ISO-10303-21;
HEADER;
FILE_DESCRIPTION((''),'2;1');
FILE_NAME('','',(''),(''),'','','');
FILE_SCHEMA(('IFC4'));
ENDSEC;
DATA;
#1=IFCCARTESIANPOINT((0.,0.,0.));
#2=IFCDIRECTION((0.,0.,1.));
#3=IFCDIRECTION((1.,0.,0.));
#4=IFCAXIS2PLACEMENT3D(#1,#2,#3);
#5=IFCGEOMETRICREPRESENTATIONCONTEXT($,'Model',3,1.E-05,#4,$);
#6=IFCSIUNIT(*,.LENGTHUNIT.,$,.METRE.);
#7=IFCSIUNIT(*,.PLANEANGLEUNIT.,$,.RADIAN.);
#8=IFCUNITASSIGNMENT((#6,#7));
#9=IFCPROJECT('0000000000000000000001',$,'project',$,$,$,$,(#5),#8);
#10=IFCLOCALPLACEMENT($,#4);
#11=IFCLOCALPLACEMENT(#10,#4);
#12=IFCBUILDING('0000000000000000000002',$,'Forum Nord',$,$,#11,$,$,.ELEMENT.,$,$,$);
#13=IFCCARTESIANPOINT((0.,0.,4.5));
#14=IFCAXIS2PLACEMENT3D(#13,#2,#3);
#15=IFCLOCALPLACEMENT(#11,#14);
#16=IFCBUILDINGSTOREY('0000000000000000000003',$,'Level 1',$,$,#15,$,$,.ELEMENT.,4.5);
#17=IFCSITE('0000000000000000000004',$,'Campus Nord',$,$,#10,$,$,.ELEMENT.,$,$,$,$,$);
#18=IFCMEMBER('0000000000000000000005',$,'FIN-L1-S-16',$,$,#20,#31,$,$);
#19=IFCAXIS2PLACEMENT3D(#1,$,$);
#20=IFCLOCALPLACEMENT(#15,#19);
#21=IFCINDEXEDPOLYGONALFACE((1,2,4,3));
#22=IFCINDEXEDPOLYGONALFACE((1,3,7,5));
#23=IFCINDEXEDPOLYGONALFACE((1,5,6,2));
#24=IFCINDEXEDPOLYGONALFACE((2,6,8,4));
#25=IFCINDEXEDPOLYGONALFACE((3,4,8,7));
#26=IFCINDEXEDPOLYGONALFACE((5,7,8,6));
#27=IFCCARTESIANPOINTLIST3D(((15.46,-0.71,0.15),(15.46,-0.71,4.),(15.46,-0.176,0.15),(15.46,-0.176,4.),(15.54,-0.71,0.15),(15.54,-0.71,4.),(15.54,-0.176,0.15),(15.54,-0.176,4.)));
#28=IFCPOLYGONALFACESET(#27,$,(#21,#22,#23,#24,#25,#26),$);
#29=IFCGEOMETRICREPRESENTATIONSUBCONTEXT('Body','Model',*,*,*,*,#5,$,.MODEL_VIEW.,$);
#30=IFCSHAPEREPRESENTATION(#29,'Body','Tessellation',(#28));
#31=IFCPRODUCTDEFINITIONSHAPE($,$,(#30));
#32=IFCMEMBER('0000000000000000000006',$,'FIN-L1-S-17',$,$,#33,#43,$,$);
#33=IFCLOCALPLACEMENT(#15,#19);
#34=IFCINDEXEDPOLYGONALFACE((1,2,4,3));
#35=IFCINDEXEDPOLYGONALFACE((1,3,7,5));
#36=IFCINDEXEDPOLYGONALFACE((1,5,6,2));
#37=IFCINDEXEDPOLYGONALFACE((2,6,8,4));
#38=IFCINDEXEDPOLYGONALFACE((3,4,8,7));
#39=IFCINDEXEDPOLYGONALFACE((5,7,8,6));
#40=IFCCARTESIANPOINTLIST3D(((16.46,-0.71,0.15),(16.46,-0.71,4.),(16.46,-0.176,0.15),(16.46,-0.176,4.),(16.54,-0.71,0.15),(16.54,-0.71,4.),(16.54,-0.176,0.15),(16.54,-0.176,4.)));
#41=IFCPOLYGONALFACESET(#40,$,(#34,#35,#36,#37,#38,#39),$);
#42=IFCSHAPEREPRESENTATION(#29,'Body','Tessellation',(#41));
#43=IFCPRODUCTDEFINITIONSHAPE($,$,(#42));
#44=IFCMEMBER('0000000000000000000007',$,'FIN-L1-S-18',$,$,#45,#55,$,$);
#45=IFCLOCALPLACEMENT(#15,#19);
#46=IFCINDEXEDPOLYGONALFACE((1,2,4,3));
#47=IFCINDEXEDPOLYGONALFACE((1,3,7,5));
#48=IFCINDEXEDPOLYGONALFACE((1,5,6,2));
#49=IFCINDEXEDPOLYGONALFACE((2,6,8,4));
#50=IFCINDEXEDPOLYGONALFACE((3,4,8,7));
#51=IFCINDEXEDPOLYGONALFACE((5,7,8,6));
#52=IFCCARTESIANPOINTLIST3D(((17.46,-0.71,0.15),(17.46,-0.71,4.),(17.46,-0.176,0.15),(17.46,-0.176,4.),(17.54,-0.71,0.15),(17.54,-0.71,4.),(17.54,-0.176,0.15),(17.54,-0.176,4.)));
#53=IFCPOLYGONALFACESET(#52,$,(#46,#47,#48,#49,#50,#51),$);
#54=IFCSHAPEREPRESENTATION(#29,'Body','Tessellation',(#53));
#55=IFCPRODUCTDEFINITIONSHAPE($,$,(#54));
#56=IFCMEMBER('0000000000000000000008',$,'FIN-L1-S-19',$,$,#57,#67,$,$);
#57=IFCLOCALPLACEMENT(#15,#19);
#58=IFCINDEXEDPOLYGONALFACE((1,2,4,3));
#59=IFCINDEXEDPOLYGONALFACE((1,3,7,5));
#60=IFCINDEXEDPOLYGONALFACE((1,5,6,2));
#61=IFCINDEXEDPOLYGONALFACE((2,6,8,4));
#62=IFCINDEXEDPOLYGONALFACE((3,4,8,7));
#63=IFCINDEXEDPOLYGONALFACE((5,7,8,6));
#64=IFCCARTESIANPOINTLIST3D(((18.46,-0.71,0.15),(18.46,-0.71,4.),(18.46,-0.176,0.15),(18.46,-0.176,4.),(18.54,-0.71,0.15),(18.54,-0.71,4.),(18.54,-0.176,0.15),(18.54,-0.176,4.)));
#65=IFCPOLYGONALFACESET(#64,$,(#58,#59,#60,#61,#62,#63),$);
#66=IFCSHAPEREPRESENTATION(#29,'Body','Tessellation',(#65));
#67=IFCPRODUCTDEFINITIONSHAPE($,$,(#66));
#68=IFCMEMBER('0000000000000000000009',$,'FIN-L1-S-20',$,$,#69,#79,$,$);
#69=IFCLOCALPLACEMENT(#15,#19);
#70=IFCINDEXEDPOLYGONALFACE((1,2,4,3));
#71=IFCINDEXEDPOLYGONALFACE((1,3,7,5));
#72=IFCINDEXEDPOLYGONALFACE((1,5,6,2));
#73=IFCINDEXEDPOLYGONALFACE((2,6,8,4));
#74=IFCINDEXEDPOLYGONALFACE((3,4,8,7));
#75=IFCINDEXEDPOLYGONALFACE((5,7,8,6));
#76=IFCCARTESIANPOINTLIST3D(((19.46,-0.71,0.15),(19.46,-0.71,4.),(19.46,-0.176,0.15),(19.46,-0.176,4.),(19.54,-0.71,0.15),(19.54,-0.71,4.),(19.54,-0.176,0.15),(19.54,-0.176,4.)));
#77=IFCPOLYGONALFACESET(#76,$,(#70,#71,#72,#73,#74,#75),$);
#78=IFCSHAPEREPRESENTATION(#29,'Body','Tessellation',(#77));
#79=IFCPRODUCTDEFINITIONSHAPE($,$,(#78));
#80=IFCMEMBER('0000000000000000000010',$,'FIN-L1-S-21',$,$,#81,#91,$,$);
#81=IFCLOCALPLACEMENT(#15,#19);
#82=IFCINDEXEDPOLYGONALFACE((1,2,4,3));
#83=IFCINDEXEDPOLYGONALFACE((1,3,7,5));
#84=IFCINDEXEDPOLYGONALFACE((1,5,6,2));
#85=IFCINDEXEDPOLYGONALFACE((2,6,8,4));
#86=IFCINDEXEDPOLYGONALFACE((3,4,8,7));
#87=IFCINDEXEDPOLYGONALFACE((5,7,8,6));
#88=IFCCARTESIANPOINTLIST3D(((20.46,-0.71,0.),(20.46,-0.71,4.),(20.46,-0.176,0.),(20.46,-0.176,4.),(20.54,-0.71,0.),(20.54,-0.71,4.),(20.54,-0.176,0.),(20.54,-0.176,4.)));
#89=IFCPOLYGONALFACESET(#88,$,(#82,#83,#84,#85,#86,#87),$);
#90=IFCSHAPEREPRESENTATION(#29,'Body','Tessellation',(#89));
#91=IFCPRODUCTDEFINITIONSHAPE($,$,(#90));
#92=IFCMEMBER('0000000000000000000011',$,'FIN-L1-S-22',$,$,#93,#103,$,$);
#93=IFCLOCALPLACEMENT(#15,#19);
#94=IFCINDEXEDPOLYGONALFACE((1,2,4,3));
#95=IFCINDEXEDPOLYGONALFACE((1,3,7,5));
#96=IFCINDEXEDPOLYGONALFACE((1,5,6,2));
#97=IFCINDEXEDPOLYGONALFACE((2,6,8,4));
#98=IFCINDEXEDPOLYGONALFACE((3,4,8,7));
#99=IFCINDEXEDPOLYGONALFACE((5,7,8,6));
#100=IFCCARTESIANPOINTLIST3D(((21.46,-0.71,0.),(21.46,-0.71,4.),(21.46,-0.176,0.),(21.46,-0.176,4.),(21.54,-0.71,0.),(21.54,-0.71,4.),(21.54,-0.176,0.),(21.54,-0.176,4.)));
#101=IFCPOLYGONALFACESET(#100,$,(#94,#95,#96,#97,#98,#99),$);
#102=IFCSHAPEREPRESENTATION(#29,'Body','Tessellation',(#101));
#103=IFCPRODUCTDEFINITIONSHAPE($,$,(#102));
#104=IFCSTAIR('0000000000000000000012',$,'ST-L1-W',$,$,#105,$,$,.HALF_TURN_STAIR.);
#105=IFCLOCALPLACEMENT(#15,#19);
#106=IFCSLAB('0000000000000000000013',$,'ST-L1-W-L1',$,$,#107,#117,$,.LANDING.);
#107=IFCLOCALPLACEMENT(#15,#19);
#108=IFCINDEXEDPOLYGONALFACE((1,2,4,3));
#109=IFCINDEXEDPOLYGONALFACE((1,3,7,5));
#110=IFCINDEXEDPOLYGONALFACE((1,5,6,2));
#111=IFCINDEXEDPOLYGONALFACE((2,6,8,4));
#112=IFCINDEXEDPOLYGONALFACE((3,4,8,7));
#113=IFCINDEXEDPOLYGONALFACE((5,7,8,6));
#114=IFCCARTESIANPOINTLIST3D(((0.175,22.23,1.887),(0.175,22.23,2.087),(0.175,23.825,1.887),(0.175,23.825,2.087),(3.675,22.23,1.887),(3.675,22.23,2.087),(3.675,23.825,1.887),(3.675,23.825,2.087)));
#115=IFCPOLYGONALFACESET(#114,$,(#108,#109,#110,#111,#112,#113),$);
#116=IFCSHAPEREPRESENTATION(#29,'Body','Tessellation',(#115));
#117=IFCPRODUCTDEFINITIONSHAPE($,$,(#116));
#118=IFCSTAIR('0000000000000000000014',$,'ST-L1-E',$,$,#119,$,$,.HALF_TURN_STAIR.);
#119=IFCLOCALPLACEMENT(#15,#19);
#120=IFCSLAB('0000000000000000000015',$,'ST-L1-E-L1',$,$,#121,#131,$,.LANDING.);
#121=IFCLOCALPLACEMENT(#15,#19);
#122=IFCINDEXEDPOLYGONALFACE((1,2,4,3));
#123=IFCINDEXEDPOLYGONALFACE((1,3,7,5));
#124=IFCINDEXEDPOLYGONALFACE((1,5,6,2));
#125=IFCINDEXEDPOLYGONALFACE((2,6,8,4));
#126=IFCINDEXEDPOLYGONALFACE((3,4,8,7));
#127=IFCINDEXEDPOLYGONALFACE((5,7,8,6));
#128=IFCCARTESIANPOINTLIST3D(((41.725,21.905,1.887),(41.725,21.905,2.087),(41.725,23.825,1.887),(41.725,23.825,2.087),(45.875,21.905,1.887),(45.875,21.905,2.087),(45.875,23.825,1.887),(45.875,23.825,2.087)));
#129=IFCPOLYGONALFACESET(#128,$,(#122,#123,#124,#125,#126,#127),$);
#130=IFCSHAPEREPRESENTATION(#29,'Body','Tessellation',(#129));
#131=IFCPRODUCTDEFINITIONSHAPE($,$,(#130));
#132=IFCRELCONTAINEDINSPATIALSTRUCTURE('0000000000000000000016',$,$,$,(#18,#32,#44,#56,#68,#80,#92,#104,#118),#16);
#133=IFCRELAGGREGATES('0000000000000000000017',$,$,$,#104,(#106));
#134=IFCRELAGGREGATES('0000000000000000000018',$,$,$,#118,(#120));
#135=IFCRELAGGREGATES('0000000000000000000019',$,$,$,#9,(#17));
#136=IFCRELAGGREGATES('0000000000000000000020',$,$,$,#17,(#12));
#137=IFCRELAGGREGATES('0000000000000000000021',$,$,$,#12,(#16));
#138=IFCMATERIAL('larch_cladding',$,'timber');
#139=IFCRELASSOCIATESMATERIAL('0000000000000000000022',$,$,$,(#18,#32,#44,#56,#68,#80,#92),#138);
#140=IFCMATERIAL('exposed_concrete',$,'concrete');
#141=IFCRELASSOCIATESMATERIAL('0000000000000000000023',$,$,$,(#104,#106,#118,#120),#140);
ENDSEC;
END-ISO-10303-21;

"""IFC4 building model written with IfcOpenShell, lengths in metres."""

from ifc_helpers import new_model, si_unit, frame, origin_with_axes, place, context, subcontext, project, spatial, polyline, outline, extrude, material, element, aggregate, save


model = new_model("IFC4")

# Units and contexts
model_context = context("Model", 3, precision=1e-05, world=origin_with_axes())
body_context = subcontext(model_context, "Body", "Model", "MODEL_VIEW")
ifc_project = project(units=[si_unit("LENGTHUNIT", "METRE"), si_unit("PLANEANGLEUNIT", "RADIAN")], contexts=[model_context])

# Site, building, storey
site_placement = place(None, origin_with_axes())
site = spatial("IfcSite", under=ifc_project, at=site_placement, Name="Campus Nord", CompositionType="ELEMENT")
building_placement = place(site_placement, origin_with_axes())
building = spatial("IfcBuilding", under=site, at=building_placement, Name="Forum Nord", CompositionType="ELEMENT")
storey_placement = place(building_placement, frame((0.0, 0.0, 4.5), z_axis=(0.0, 0.0, 1.0), x_axis=(1.0, 0.0, 0.0)))
storey = spatial("IfcBuildingStorey", under=building, at=storey_placement, Name="Level 1", CompositionType="ELEMENT", Elevation=4.5)

# Members
ifc_material_1 = material(Name="larch_cladding", Category="timber")
member_1_placement = place(storey_placement, frame((0.0, 0.0, 0.15), z_axis=(0.0, 0.0, 1.0), x_axis=(1.0, 0.0, 0.0)))
element("IfcMember", 1, at=member_1_placement, inside=storey, material=ifc_material_1, Name="FIN-L1-S-16", context=body_context, shape_type="SweptSolid", body=[
    extrude(outline(polyline([(15.54, -0.71), (15.54, -0.176), (15.46, -0.176), (15.46, -0.71), (15.54, -0.71)])), origin_with_axes(), (0.0, 0.0, 1.0), 3.85),
])
member_2_placement = place(storey_placement, frame((0.0, 0.0, 0.15), z_axis=(0.0, 0.0, 1.0), x_axis=(1.0, 0.0, 0.0)))
element("IfcMember", 2, at=member_2_placement, inside=storey, material=ifc_material_1, Name="FIN-L1-S-17", context=body_context, shape_type="SweptSolid", body=[
    extrude(outline(polyline([(16.54, -0.71), (16.54, -0.176), (16.46, -0.176), (16.46, -0.71), (16.54, -0.71)])), origin_with_axes(), (0.0, 0.0, 1.0), 3.85),
])
member_3_placement = place(storey_placement, frame((0.0, 0.0, 0.15), z_axis=(0.0, 0.0, 1.0), x_axis=(1.0, 0.0, 0.0)))
element("IfcMember", 3, at=member_3_placement, inside=storey, material=ifc_material_1, Name="FIN-L1-S-18", context=body_context, shape_type="SweptSolid", body=[
    extrude(outline(polyline([(17.54, -0.71), (17.54, -0.176), (17.46, -0.176), (17.46, -0.71), (17.54, -0.71)])), origin_with_axes(), (0.0, 0.0, 1.0), 3.85),
])
member_4_placement = place(storey_placement, frame((0.0, 0.0, 0.15), z_axis=(0.0, 0.0, 1.0), x_axis=(1.0, 0.0, 0.0)))
element("IfcMember", 4, at=member_4_placement, inside=storey, material=ifc_material_1, Name="FIN-L1-S-19", context=body_context, shape_type="SweptSolid", body=[
    extrude(outline(polyline([(18.54, -0.71), (18.54, -0.176), (18.46, -0.176), (18.46, -0.71), (18.54, -0.71)])), origin_with_axes(), (0.0, 0.0, 1.0), 3.85),
])
member_5_placement = place(storey_placement, frame((0.0, 0.0, 0.15), z_axis=(0.0, 0.0, 1.0), x_axis=(1.0, 0.0, 0.0)))
element("IfcMember", 5, at=member_5_placement, inside=storey, material=ifc_material_1, Name="FIN-L1-S-20", context=body_context, shape_type="SweptSolid", body=[
    extrude(outline(polyline([(19.54, -0.71), (19.54, -0.176), (19.46, -0.176), (19.46, -0.71), (19.54, -0.71)])), origin_with_axes(), (0.0, 0.0, 1.0), 3.85),
])
member_6_placement = place(storey_placement, origin_with_axes())
element("IfcMember", 6, at=member_6_placement, inside=storey, material=ifc_material_1, Name="FIN-L1-S-21", context=body_context, shape_type="SweptSolid", body=[
    extrude(outline(polyline([(20.54, -0.71), (20.54, -0.176), (20.46, -0.176), (20.46, -0.71), (20.54, -0.71)])), origin_with_axes(), (0.0, 0.0, 1.0), 4.0),
])
member_7_placement = place(storey_placement, origin_with_axes())
element("IfcMember", 7, at=member_7_placement, inside=storey, material=ifc_material_1, Name="FIN-L1-S-22", context=body_context, shape_type="SweptSolid", body=[
    extrude(outline(polyline([(21.54, -0.71), (21.54, -0.176), (21.46, -0.176), (21.46, -0.71), (21.54, -0.71)])), origin_with_axes(), (0.0, 0.0, 1.0), 4.0),
])

# Stairs, slabs
ifc_material_2 = material(Name="exposed_concrete", Category="concrete")
stair_1_placement = place(storey_placement, origin_with_axes())
stair_1 = element("IfcStair", 8, at=stair_1_placement, inside=storey, material=ifc_material_2, Name="ST-L1-W", PredefinedType="HALF_TURN_STAIR")
slab_1_placement = place(storey_placement, frame((0.0, 0.0, 2.087), z_axis=(0.0, 0.0, 1.0), x_axis=(1.0, 0.0, 0.0)))
slab_1 = element("IfcSlab", 9, at=slab_1_placement, material=ifc_material_2, Name="ST-L1-W-L1", PredefinedType="LANDING", context=body_context, shape_type="SweptSolid", body=[
    extrude(outline(polyline([(0.175, 22.23), (3.675, 22.23), (3.675, 23.825), (0.175, 23.825), (0.175, 22.23)])), frame((0.0, 0.0, -0.2), z_axis=(0.0, 0.0, 1.0), x_axis=(1.0, 0.0, 0.0)), (0.0, 0.0, 1.0), 0.2),
])
aggregate(stair_1, [slab_1])
stair_2_placement = place(storey_placement, origin_with_axes())
stair_2 = element("IfcStair", 10, at=stair_2_placement, inside=storey, material=ifc_material_2, Name="ST-L1-E", PredefinedType="HALF_TURN_STAIR")
slab_2_placement = place(storey_placement, frame((0.0, 0.0, 2.087), z_axis=(0.0, 0.0, 1.0), x_axis=(1.0, 0.0, 0.0)))
slab_2 = element("IfcSlab", 11, at=slab_2_placement, material=ifc_material_2, Name="ST-L1-E-L1", PredefinedType="LANDING", context=body_context, shape_type="SweptSolid", body=[
    extrude(outline(polyline([(41.725, 21.905), (45.875, 21.905), (45.875, 23.825), (41.725, 23.825), (41.725, 21.905)])), frame((0.0, 0.0, -0.2), z_axis=(0.0, 0.0, 1.0), x_axis=(1.0, 0.0, 0.0)), (0.0, 0.0, 1.0), 0.2),
])
aggregate(stair_2, [slab_2])

save(model, "model.ifc")
